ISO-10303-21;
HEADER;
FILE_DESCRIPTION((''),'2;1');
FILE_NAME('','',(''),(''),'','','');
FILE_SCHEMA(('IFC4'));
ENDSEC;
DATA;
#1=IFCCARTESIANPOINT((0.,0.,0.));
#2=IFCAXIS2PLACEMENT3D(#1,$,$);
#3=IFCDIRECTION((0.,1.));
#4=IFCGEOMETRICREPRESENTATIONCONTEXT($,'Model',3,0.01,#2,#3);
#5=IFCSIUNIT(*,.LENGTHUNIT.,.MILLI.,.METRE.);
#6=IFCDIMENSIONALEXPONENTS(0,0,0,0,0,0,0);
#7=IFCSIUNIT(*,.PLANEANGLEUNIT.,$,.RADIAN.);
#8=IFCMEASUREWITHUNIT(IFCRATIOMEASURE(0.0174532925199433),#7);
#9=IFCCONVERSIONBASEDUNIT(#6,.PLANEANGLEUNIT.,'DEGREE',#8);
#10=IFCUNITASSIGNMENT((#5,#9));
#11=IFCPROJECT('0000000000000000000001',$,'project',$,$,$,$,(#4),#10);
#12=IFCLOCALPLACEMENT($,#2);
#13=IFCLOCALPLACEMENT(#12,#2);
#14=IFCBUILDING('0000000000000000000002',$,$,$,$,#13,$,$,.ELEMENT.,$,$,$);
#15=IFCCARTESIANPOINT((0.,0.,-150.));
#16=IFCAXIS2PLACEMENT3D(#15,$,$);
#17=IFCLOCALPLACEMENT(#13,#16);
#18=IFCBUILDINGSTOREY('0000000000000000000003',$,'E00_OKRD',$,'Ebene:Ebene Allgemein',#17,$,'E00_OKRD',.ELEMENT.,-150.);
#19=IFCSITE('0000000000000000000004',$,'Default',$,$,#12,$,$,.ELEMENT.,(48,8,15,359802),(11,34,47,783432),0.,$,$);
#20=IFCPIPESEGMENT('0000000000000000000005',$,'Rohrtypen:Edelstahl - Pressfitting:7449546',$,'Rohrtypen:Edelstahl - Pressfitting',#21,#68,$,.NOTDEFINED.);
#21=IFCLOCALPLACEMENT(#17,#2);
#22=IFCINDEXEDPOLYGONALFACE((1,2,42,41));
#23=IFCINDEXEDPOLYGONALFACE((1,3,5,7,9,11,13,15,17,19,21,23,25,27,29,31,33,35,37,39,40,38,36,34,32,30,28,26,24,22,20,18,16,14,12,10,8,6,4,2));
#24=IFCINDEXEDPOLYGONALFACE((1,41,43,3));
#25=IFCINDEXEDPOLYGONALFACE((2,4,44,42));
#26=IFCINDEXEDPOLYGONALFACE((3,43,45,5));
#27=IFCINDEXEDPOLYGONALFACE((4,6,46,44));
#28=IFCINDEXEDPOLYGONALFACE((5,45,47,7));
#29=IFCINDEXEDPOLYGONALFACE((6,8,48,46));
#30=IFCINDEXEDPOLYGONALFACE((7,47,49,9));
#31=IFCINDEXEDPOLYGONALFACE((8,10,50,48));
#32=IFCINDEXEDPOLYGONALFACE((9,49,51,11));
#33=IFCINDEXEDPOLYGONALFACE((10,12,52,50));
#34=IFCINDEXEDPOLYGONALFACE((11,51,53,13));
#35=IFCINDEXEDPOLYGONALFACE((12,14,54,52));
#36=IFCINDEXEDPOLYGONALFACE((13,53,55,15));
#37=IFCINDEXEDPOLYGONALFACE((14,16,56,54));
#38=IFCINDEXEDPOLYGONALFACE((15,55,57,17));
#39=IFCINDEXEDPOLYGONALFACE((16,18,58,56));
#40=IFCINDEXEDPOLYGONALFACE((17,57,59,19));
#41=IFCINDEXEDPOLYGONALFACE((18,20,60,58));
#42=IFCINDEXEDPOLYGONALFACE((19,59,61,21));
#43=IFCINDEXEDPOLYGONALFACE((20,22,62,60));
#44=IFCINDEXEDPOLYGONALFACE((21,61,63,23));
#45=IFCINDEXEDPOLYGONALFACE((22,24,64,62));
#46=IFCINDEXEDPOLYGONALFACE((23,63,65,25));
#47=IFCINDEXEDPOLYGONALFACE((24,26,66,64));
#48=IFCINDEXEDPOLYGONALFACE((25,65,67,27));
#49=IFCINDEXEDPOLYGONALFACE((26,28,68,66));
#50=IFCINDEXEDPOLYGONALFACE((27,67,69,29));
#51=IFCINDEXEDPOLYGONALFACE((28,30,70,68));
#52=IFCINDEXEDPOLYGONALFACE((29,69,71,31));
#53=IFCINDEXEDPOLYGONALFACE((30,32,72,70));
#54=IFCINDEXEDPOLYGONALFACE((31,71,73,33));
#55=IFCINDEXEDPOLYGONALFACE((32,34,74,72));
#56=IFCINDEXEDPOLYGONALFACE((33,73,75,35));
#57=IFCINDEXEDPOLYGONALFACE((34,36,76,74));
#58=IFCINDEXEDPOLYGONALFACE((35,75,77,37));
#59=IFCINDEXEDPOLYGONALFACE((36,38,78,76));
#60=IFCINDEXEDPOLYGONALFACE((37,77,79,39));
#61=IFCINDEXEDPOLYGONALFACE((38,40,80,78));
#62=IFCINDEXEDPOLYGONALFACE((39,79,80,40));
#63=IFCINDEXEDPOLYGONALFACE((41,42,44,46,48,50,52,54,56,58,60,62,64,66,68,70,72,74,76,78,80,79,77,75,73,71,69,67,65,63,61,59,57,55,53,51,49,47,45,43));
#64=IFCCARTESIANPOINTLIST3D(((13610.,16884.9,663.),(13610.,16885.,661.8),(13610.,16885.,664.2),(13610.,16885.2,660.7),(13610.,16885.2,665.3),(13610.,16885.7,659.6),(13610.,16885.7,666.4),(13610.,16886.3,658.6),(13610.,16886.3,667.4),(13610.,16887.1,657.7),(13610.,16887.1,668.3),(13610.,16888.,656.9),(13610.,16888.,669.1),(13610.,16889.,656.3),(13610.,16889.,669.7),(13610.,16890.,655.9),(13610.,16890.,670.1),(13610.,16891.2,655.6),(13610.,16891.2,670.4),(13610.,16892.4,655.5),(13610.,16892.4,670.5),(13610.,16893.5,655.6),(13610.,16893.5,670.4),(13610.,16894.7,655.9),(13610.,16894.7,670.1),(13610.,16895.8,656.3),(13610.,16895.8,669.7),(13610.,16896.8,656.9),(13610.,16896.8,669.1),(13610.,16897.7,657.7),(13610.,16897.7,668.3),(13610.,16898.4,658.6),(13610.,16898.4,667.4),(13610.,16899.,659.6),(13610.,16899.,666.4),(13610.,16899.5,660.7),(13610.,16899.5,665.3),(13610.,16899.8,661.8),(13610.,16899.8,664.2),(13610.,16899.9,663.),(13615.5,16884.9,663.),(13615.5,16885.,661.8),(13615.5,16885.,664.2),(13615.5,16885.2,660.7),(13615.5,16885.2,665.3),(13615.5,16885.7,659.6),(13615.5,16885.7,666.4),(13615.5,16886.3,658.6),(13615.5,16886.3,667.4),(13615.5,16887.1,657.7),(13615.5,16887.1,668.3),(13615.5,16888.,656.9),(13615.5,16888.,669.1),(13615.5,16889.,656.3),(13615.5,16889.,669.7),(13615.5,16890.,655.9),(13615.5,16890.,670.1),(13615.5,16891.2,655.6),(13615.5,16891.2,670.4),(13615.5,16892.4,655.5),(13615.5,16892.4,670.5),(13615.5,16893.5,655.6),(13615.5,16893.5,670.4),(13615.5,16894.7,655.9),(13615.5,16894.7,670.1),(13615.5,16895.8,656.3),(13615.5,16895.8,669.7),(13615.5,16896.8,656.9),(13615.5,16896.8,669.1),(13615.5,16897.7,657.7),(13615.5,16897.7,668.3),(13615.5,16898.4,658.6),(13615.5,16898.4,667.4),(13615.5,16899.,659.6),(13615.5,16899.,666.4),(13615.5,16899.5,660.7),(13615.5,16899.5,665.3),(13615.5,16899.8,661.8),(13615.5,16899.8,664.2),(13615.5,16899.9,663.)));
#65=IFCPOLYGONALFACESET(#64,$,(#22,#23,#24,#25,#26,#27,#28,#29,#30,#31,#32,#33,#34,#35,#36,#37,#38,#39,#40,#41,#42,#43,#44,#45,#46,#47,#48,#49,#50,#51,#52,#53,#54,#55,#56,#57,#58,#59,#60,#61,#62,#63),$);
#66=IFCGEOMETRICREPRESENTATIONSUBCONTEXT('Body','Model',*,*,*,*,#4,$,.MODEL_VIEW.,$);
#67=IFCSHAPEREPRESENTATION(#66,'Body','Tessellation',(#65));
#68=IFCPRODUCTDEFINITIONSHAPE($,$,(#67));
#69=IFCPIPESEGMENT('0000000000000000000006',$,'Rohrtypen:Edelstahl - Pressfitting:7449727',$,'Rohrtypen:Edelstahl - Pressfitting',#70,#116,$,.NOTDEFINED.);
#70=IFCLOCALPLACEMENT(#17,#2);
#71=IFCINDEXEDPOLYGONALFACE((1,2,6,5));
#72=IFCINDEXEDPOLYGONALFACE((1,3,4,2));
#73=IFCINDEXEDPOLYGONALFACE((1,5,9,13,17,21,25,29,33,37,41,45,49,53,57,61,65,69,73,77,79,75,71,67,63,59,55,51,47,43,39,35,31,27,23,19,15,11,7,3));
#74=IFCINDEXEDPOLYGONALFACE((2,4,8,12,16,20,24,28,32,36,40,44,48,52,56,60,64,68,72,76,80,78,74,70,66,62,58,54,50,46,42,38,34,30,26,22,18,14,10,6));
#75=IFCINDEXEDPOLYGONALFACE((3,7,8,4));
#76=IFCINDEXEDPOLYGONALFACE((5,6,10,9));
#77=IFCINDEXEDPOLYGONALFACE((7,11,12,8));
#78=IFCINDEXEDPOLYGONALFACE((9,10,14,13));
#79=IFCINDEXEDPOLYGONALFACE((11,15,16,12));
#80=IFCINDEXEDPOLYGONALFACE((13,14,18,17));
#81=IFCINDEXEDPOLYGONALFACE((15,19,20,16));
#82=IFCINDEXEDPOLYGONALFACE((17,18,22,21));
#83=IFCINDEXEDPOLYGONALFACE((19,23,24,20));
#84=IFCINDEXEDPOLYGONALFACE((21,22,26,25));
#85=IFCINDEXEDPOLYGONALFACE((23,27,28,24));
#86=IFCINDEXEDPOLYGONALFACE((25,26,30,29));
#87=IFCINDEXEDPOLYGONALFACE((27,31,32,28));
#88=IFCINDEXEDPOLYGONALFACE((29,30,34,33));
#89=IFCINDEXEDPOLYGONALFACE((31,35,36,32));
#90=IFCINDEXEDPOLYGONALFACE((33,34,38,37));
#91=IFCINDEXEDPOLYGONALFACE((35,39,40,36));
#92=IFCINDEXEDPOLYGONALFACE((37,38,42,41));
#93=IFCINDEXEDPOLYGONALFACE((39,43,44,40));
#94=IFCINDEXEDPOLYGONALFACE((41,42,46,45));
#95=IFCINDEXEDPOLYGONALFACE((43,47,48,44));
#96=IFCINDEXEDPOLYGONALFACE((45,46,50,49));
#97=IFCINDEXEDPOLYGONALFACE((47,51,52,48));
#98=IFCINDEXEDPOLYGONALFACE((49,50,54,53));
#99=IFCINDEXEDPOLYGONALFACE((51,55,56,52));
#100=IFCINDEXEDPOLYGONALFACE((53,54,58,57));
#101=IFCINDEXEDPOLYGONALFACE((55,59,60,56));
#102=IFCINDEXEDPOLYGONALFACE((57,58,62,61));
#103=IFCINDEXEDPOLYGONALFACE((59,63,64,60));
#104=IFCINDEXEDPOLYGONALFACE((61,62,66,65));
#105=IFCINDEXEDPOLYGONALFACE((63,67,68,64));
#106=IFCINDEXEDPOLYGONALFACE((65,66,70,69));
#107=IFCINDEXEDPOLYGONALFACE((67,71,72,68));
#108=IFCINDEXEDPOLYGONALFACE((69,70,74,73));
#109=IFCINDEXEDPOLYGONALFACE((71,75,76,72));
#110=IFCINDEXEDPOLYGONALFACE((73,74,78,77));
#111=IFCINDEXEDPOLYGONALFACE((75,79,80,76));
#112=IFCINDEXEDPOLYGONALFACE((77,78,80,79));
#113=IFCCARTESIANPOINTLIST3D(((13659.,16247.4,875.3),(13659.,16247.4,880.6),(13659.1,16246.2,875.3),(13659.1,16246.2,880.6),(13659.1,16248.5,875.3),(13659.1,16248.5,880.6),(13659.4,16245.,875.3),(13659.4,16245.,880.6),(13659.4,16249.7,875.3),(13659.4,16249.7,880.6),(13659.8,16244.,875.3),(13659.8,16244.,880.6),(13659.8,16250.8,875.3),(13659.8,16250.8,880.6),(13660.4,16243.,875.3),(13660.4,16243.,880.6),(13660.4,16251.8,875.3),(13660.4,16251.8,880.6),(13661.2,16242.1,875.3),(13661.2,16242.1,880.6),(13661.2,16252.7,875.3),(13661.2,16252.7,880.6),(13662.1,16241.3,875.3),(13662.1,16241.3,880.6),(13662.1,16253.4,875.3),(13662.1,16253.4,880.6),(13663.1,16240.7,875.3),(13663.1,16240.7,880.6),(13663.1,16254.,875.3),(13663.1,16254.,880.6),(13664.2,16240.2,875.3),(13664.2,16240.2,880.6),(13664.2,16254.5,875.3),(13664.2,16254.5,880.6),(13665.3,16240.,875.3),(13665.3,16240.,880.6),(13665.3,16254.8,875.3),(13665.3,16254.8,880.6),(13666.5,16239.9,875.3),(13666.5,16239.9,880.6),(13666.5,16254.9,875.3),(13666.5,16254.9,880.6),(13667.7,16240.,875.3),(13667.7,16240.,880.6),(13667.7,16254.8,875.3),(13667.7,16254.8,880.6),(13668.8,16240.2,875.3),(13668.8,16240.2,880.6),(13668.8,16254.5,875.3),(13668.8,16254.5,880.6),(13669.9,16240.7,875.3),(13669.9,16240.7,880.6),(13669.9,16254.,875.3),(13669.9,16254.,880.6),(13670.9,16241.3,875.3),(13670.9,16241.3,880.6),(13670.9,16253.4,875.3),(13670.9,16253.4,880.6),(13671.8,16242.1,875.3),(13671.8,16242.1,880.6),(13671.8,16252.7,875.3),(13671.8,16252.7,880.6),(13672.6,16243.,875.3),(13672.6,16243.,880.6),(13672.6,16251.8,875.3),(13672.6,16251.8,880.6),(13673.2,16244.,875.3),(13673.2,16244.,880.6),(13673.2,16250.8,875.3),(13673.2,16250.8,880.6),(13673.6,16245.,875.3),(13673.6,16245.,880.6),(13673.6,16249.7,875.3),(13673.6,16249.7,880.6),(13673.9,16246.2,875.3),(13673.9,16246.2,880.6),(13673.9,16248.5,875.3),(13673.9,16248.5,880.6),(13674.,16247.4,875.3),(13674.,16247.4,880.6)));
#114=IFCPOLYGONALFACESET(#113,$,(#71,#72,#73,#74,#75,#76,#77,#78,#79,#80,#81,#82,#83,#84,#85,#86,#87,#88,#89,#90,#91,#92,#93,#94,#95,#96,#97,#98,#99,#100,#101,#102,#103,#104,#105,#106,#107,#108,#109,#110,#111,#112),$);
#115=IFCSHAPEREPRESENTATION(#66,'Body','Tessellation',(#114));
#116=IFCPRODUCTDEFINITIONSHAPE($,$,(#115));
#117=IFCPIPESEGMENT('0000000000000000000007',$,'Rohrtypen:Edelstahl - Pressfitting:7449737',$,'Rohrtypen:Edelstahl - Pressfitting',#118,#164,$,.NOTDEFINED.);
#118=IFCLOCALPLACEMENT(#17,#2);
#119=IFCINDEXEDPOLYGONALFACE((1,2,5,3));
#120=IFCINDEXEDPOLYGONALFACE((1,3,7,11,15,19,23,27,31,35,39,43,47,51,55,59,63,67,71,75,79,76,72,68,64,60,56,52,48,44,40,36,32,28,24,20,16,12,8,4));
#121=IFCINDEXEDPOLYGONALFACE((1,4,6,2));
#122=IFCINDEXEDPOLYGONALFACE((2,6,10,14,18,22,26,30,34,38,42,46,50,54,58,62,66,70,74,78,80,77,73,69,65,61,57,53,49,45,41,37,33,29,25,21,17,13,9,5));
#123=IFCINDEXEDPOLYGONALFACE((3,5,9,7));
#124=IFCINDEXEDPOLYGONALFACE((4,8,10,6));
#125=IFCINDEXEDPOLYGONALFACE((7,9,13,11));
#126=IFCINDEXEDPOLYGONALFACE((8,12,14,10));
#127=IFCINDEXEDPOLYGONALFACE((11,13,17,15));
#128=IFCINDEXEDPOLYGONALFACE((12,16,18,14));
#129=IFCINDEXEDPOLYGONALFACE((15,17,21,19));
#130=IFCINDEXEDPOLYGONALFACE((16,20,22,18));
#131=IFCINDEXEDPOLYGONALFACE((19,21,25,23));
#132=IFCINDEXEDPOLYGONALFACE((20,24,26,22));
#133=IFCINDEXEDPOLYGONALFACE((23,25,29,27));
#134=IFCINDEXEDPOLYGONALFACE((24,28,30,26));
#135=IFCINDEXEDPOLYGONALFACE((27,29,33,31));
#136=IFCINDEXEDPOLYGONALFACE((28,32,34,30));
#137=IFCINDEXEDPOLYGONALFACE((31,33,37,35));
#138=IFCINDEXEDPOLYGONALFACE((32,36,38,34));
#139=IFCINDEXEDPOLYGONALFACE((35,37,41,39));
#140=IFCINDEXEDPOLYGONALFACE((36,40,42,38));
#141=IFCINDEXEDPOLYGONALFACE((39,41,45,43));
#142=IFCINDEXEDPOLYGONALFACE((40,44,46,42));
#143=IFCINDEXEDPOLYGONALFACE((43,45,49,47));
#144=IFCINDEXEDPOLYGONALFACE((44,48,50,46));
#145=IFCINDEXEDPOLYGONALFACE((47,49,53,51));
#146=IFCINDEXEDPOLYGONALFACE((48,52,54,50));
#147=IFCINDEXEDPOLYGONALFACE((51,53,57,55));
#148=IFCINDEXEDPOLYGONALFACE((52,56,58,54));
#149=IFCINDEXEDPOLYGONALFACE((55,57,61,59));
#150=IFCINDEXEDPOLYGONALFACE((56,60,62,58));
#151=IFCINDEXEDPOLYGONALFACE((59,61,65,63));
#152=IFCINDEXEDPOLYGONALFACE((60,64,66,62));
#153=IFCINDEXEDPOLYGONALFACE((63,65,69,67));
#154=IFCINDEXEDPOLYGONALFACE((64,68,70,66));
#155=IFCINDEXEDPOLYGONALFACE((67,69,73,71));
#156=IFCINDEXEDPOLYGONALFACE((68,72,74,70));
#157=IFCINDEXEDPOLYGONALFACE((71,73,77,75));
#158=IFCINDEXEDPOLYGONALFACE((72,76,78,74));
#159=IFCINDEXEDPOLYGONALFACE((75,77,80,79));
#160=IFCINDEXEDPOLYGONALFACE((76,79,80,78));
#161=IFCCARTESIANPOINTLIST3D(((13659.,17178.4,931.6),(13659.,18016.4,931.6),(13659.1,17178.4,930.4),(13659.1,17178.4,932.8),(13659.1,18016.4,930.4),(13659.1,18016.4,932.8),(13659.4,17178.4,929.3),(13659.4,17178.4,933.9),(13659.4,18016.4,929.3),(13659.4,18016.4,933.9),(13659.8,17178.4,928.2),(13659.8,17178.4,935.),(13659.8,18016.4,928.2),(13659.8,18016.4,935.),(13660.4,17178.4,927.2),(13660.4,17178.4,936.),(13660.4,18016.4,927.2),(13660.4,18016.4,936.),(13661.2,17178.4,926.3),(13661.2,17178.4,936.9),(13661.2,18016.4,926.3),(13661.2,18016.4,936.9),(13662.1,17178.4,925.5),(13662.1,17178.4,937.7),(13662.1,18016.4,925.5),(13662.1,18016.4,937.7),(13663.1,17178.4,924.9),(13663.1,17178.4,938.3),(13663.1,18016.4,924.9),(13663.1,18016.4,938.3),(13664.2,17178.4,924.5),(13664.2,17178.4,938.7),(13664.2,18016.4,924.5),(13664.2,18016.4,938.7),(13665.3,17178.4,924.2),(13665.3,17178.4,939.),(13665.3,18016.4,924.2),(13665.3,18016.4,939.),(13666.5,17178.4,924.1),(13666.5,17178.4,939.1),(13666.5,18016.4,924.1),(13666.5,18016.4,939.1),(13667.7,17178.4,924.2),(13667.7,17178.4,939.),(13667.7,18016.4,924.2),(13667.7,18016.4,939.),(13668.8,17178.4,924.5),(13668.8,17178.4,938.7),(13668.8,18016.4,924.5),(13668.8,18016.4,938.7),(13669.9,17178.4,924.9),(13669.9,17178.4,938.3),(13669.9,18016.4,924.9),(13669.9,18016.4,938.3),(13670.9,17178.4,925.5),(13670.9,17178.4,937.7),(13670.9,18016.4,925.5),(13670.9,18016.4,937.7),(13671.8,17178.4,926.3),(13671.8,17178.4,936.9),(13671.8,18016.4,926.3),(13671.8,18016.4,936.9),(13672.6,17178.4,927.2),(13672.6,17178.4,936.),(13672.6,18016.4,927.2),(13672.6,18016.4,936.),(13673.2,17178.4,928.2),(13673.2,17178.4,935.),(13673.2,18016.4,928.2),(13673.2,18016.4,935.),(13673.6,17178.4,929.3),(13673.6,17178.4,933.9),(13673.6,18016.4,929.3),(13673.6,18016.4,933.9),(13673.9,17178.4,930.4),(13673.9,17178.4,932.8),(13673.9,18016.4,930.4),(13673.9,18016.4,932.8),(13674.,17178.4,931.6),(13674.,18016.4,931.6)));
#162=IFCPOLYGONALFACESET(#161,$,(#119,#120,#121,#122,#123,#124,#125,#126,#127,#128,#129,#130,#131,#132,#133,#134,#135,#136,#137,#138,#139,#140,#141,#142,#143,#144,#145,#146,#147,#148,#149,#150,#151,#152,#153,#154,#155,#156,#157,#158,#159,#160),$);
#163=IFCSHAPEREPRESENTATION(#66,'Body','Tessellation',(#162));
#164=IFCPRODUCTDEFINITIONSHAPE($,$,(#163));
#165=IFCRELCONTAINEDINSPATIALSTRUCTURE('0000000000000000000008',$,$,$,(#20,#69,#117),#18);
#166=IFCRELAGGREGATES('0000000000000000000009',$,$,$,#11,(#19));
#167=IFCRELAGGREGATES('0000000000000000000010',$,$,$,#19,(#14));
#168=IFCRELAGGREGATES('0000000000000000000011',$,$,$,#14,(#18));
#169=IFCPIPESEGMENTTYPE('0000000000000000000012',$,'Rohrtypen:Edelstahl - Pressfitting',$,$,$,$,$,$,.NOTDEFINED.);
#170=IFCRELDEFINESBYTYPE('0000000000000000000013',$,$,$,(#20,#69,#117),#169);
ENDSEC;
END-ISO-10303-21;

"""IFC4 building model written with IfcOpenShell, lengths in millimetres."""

from ifc_helpers import new_model, entity, si_unit, converted_unit, direction, frame, origin, place, context, subcontext, project, spatial, indexed_curve, outline, extrude, type_object, element, save


model = new_model("IFC4")

# Units and contexts
model_context = context("Model", 3, precision=0.01, world=origin(), true_north=direction((0.0, 1.0)))
body_context = subcontext(model_context, "Body", "Model", "MODEL_VIEW")
ifc_project = project(units=[si_unit("LENGTHUNIT", "METRE", prefix="MILLI"), converted_unit("PLANEANGLEUNIT", "DEGREE", entity("IfcRatioMeasure", 0.0174532925199433), si_unit("PLANEANGLEUNIT", "RADIAN"), dimensions=[0, 0, 0, 0, 0, 0, 0])], contexts=[model_context])

# Site, building, storey
site_placement = place(None, origin())
site = spatial("IfcSite", under=ifc_project, at=site_placement, Name="Default", CompositionType="ELEMENT", RefLatitude=(48, 8, 15, 359802), RefLongitude=(11, 34, 47, 783432), RefElevation=0.0)
building_placement = place(site_placement, origin())
building = spatial("IfcBuilding", under=site, at=building_placement, CompositionType="ELEMENT")
storey_placement = place(building_placement, frame((0.0, 0.0, -150.0)))
storey = spatial("IfcBuildingStorey", under=building, at=storey_placement, Name="E00_OKRD", ObjectType="Ebene:Ebene Allgemein", LongName="E00_OKRD", CompositionType="ELEMENT", Elevation=-150.0)

# Pipe segments
pipe_segment_type_1 = type_object("IfcPipeSegmentType", Name="Rohrtypen:Edelstahl - Pressfitting", PredefinedType="NOTDEFINED")
pipe_segment_1_placement = place(storey_placement, origin())
element("IfcPipeSegment", 1, at=pipe_segment_1_placement, inside=storey, type_object=pipe_segment_type_1, Name="Rohrtypen:Edelstahl - Pressfitting:7449546", ObjectType="Rohrtypen:Edelstahl - Pressfitting", PredefinedType="NOTDEFINED", context=body_context, shape_type="SweptSolid", body=[
    extrude(outline(indexed_curve([(7.5, 0.0), (7.4, 1.2), (7.1, 2.3), (6.7, 3.4), (6.1, 4.4), (5.3, 5.3), (4.4, 6.1), (3.4, 6.7), (2.3, 7.1), (1.2, 7.4), (0.0, 7.5), (-1.2, 7.4), (-2.3, 7.1), (-3.4, 6.7), (-4.4, 6.1), (-5.3, 5.3), (-6.1, 4.4), (-6.7, 3.4), (-7.1, 2.3), (-7.4, 1.2), (-7.5, 0.0), (-7.4, -1.2), (-7.1, -2.3), (-6.7, -3.4), (-6.1, -4.4), (-5.3, -5.3), (-4.4, -6.1), (-3.4, -6.7), (-2.3, -7.1), (-1.2, -7.4), (0.0, -7.5), (1.2, -7.4), (2.3, -7.1), (3.4, -6.7), (4.4, -6.1), (5.3, -5.3), (6.1, -4.4), (6.7, -3.4), (7.1, -2.3), (7.4, -1.2), (7.5, 0.0)], self_intersect=False)), frame((13610.0, 16892.4, 663.0), z_axis=(1.0, 0.0, 0.0), x_axis=(0.0, -1.0, 0.0)), (0.0, 0.0, 1.0), 5.6),
])
pipe_segment_2_placement = place(storey_placement, origin())
element("IfcPipeSegment", 2, at=pipe_segment_2_placement, inside=storey, type_object=pipe_segment_type_1, Name="Rohrtypen:Edelstahl - Pressfitting:7449727", ObjectType="Rohrtypen:Edelstahl - Pressfitting", PredefinedType="NOTDEFINED", context=body_context, shape_type="SweptSolid", body=[
    extrude(outline(indexed_curve([(7.5, 0.0), (7.4, 1.2), (7.1, 2.3), (6.7, 3.4), (6.1, 4.4), (5.3, 5.3), (4.4, 6.1), (3.4, 6.7), (2.3, 7.1), (1.2, 7.4), (0.0, 7.5), (-1.2, 7.4), (-2.3, 7.1), (-3.4, 6.7), (-4.4, 6.1), (-5.3, 5.3), (-6.1, 4.4), (-6.7, 3.4), (-7.1, 2.3), (-7.4, 1.2), (-7.5, 0.0), (-7.4, -1.2), (-7.1, -2.3), (-6.7, -3.4), (-6.1, -4.4), (-5.3, -5.3), (-4.4, -6.1), (-3.4, -6.7), (-2.3, -7.1), (-1.2, -7.4), (0.0, -7.5), (1.2, -7.4), (2.3, -7.1), (3.4, -6.7), (4.4, -6.1), (5.3, -5.3), (6.1, -4.4), (6.7, -3.4), (7.1, -2.3), (7.4, -1.2), (7.5, 0.0)], self_intersect=False)), frame((13666.5, 16247.4, 875.3), z_axis=(0.0, 0.0, 1.0), x_axis=(-1.0, 0.0, 0.0)), (0.0, 0.0, 1.0), 5.3),
])
pipe_segment_3_placement = place(storey_placement, origin())
element("IfcPipeSegment", 3, at=pipe_segment_3_placement, inside=storey, type_object=pipe_segment_type_1, Name="Rohrtypen:Edelstahl - Pressfitting:7449737", ObjectType="Rohrtypen:Edelstahl - Pressfitting", PredefinedType="NOTDEFINED", context=body_context, shape_type="SweptSolid", body=[
    extrude(outline(indexed_curve([(7.5, 0.0), (7.4, 1.2), (7.1, 2.3), (6.7, 3.4), (6.1, 4.4), (5.3, 5.3), (4.4, 6.1), (3.4, 6.7), (2.3, 7.1), (1.2, 7.4), (0.0, 7.5), (-1.2, 7.4), (-2.3, 7.1), (-3.4, 6.7), (-4.4, 6.1), (-5.3, 5.3), (-6.1, 4.4), (-6.7, 3.4), (-7.1, 2.3), (-7.4, 1.2), (-7.5, 0.0), (-7.4, -1.2), (-7.1, -2.3), (-6.7, -3.4), (-6.1, -4.4), (-5.3, -5.3), (-4.4, -6.1), (-3.4, -6.7), (-2.3, -7.1), (-1.2, -7.4), (0.0, -7.5), (1.2, -7.4), (2.3, -7.1), (3.4, -6.7), (4.4, -6.1), (5.3, -5.3), (6.1, -4.4), (6.7, -3.4), (7.1, -2.3), (7.4, -1.2), (7.5, 0.0)], self_intersect=False)), frame((13666.5, 17178.4, 931.6), z_axis=(-0.000003, 1.0, 0.0), x_axis=(1.0, 0.000003, 0.0)), (0.0, 0.0, 1.0), 838.0),
])

save(model, "model.ifc")
